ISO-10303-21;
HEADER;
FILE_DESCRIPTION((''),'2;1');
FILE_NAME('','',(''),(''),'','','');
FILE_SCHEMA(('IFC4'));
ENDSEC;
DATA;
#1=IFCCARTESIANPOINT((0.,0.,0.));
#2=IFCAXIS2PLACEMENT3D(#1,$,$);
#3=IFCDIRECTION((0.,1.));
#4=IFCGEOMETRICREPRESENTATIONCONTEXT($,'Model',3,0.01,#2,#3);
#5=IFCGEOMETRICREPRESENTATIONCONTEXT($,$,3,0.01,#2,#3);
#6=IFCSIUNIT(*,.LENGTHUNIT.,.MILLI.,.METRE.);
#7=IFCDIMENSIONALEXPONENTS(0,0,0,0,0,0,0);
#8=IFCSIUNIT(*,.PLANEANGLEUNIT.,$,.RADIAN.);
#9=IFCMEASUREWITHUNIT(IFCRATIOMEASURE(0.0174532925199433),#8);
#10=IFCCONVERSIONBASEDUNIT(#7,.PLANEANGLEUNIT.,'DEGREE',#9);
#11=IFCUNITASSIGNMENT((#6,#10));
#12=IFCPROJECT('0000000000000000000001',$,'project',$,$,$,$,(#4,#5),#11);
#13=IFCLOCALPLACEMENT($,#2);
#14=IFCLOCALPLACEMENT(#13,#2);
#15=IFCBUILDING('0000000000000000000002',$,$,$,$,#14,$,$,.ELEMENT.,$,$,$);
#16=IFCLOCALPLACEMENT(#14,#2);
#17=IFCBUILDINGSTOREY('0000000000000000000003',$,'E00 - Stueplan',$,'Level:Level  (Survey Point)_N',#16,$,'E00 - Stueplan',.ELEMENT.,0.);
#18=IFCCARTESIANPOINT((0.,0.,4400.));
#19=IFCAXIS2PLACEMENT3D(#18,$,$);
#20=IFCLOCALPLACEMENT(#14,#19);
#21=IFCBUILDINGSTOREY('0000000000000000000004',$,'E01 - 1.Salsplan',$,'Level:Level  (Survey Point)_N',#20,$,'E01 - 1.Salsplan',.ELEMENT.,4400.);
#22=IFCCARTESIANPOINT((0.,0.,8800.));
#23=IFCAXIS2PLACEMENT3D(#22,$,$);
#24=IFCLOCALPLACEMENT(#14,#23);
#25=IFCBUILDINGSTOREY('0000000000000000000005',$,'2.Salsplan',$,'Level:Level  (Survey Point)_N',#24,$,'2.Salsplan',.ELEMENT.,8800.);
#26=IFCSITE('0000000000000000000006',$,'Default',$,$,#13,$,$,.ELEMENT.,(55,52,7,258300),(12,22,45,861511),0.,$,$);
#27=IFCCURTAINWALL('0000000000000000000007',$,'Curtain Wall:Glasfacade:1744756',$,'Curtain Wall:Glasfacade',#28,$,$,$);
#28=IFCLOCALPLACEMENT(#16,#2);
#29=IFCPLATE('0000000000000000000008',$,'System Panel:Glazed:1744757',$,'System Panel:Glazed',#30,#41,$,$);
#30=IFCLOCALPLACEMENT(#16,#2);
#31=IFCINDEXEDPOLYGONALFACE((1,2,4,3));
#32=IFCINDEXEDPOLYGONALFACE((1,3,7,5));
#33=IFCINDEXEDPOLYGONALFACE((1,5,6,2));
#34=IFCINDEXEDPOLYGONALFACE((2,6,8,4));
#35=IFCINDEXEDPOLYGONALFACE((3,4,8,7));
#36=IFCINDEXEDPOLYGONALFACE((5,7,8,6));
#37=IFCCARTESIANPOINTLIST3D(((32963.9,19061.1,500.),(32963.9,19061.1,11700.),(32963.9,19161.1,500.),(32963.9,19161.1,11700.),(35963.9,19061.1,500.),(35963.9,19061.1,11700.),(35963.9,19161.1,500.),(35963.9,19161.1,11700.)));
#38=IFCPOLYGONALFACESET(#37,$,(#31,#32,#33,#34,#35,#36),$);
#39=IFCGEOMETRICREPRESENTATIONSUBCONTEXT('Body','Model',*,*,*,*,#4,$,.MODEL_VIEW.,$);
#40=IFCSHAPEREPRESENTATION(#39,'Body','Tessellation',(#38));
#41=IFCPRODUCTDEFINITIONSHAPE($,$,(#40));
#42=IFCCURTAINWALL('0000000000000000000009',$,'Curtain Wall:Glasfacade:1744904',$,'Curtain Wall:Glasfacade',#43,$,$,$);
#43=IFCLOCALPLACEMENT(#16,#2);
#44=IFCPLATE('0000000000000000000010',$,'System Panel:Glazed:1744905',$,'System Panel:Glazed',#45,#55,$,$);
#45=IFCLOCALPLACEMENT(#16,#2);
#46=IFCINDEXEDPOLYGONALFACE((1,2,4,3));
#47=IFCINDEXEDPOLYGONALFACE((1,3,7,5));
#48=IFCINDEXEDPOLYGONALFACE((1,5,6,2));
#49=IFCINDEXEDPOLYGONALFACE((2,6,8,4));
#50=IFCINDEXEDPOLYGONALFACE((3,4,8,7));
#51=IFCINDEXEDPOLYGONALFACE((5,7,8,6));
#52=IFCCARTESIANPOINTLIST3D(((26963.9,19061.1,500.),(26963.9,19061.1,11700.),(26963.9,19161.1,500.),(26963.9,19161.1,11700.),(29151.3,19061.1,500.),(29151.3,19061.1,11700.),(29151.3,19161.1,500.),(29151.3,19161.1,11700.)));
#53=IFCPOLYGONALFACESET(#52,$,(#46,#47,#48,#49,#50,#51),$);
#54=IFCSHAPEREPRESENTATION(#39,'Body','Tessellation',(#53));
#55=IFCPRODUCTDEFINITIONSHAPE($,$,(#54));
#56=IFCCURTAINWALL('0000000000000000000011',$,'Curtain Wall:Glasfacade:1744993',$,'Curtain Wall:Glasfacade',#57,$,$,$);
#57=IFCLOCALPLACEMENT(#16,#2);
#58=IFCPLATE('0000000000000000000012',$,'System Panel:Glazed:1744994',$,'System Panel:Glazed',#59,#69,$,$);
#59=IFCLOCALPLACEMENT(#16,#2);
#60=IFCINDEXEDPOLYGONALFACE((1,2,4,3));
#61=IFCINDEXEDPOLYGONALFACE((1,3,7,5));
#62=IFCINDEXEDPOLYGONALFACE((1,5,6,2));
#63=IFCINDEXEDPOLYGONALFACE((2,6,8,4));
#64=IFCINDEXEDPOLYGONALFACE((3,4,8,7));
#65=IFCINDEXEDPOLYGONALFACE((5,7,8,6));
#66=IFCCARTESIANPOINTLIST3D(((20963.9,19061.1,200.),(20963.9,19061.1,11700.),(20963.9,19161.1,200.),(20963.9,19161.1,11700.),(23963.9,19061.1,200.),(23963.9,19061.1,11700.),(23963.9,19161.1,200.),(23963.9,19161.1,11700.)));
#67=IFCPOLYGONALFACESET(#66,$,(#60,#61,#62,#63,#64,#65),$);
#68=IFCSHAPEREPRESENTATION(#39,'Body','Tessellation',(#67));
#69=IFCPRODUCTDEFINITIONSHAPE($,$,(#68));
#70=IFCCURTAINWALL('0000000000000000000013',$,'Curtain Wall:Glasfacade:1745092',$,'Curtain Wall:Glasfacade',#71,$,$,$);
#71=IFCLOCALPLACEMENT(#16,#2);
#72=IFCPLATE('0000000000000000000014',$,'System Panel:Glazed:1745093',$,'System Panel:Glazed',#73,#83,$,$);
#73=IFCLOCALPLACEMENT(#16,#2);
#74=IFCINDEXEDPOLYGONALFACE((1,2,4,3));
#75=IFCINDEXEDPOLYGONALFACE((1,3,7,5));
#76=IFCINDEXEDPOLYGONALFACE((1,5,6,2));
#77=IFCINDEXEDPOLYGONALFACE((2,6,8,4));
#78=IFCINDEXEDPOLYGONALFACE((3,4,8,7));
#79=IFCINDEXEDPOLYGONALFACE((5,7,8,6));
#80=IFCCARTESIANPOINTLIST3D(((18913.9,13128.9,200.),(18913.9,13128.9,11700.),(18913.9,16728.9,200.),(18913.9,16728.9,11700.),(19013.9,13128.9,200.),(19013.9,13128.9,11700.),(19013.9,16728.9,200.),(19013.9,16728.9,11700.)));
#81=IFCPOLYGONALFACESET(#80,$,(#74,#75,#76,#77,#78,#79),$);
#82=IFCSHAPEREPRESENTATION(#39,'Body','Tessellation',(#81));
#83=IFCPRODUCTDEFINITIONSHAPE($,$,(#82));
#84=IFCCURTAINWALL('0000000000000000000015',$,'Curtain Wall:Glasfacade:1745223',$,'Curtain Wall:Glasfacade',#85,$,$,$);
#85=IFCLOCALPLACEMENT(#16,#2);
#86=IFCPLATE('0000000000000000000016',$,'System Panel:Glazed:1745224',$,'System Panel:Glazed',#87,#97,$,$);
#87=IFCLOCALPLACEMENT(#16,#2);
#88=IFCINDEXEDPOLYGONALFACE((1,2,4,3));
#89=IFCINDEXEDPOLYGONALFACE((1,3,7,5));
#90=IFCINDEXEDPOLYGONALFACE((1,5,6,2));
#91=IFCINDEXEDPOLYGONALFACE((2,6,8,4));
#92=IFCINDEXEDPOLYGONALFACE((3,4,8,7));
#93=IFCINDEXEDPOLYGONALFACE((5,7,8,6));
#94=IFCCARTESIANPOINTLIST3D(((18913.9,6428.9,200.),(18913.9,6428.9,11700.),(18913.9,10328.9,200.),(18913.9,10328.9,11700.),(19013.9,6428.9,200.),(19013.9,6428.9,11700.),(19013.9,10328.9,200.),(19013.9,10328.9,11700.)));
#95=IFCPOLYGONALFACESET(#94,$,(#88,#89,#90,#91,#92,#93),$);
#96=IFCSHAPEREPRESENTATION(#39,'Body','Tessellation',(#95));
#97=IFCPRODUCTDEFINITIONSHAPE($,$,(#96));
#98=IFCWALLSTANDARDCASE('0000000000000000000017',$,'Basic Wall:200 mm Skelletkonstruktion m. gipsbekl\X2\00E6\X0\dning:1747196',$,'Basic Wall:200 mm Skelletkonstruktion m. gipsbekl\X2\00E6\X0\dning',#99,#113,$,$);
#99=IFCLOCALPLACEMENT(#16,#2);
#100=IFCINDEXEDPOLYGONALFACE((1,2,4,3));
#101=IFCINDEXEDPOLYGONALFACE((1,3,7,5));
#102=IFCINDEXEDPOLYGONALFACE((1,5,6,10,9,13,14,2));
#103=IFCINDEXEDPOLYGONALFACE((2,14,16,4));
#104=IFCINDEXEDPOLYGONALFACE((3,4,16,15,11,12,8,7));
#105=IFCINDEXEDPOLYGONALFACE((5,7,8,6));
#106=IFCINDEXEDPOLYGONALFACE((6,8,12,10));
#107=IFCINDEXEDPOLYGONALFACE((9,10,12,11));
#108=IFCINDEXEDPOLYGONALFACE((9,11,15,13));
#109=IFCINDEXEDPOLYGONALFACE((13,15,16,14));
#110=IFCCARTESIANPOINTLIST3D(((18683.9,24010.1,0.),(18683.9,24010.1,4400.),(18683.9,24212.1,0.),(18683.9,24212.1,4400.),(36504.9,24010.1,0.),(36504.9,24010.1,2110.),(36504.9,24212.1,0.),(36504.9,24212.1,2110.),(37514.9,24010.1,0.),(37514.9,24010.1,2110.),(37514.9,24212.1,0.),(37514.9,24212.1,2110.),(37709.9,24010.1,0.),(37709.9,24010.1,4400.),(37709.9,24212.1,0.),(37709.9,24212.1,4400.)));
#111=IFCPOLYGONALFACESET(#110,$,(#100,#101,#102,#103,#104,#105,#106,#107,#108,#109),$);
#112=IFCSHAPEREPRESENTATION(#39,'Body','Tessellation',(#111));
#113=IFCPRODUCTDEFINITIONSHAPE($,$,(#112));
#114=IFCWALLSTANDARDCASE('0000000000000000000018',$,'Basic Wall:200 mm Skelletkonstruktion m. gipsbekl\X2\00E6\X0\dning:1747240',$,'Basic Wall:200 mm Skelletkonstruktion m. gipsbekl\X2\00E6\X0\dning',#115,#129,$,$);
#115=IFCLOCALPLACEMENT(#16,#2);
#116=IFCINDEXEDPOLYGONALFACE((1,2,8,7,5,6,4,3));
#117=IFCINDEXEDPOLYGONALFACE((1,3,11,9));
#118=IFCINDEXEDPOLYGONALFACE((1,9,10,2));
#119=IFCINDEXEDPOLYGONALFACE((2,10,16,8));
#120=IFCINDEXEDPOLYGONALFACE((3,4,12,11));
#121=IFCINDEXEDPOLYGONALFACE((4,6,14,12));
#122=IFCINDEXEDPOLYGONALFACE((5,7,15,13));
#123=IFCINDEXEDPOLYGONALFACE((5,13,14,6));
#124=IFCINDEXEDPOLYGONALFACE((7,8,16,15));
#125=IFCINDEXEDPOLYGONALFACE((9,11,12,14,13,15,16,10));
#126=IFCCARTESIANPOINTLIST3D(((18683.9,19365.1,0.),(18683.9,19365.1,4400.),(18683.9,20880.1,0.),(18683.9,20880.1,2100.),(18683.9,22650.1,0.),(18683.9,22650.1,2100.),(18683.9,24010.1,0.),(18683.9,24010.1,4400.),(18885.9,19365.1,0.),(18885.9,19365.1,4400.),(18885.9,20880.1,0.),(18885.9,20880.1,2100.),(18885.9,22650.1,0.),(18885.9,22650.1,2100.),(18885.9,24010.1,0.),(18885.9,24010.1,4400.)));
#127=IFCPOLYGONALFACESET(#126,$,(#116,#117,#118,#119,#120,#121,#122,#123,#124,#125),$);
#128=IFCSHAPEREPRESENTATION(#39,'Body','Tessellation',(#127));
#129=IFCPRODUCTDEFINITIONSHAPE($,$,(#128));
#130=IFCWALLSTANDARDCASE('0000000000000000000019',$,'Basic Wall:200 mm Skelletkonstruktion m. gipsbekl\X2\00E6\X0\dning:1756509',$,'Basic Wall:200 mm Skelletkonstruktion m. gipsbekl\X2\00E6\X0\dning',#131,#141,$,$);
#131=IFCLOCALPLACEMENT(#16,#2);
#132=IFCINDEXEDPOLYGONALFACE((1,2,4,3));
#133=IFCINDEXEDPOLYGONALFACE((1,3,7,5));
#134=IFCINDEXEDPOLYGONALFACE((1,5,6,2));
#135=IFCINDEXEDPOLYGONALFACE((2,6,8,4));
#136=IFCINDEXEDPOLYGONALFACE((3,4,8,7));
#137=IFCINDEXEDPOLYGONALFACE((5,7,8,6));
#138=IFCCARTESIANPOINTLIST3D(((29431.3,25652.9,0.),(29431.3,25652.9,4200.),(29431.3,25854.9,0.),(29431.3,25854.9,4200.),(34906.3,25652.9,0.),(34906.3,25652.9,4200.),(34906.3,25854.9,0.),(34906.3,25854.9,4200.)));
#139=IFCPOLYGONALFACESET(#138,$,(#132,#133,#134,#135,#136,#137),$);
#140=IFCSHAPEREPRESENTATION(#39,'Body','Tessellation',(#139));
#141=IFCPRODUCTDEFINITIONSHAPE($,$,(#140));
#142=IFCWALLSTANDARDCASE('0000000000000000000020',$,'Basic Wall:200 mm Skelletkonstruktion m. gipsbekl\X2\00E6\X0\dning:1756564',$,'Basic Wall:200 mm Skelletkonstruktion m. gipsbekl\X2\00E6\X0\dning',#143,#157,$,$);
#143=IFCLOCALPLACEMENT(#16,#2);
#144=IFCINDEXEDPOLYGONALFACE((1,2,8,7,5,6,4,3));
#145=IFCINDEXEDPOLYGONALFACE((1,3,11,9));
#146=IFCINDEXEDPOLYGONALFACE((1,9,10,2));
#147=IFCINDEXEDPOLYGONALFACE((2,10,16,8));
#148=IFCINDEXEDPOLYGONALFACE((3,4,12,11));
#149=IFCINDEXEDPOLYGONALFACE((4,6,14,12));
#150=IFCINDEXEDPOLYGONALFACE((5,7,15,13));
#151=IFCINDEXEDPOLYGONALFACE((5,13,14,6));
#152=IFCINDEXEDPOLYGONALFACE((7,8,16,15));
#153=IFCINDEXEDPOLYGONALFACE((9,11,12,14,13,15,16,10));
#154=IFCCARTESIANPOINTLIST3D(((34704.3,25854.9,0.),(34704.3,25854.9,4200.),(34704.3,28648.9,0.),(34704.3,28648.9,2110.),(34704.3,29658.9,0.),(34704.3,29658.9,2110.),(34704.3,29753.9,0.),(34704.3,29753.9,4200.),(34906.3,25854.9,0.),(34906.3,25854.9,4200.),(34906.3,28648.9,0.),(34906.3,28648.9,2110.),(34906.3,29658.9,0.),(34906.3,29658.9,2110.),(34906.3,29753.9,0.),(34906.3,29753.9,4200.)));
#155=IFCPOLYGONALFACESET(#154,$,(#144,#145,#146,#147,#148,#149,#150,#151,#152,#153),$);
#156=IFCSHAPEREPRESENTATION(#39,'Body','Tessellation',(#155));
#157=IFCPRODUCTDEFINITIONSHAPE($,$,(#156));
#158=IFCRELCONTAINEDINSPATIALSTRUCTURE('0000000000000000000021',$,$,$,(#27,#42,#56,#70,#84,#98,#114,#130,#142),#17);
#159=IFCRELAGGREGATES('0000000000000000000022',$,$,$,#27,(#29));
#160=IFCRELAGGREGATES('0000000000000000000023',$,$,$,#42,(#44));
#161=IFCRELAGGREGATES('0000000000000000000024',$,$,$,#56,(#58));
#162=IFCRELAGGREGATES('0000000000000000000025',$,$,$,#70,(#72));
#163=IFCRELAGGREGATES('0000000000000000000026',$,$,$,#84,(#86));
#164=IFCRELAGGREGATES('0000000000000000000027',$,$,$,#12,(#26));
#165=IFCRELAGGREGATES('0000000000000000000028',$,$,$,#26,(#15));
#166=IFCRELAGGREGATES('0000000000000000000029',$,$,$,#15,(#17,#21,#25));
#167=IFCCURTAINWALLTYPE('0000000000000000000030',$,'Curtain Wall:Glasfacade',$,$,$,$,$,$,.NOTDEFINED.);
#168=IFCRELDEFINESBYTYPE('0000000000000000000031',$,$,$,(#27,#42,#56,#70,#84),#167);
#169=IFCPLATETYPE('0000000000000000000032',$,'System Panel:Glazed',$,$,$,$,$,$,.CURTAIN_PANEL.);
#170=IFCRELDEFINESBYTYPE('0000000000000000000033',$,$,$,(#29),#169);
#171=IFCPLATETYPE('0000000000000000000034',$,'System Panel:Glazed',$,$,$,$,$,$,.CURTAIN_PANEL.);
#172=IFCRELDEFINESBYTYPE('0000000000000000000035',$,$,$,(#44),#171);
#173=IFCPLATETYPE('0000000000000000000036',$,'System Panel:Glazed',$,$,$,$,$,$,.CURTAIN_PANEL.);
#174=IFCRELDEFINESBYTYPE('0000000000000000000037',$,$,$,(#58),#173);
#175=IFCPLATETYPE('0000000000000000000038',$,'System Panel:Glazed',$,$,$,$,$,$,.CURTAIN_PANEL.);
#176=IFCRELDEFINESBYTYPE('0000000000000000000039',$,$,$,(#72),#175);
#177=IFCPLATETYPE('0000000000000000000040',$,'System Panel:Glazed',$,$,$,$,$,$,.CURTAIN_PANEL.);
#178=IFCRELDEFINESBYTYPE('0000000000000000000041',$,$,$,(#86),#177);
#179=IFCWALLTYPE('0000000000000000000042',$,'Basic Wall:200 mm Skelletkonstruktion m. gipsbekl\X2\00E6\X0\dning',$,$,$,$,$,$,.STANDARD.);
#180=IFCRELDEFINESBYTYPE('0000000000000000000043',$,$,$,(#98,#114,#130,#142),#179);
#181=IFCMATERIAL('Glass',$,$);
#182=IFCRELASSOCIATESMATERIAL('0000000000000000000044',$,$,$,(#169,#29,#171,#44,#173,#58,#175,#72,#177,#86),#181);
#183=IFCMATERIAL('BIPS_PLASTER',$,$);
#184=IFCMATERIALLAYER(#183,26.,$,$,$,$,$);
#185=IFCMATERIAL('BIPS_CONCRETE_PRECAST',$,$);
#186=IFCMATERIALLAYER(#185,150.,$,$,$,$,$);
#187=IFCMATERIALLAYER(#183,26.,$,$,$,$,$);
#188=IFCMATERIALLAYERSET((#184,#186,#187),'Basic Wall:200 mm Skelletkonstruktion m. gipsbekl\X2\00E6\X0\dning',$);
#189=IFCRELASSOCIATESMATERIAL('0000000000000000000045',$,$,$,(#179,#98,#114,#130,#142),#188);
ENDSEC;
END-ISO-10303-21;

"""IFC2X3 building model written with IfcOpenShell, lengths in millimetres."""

from ifc_helpers import new_model, entity, si_unit, converted_unit, direction, frame, frame_2d, origin, origin_2d_with_axis, place, context, subcontext, project, spatial, rectangle, extrude, source, transform, mapped, material, layer, layer_set, layer_usage, type_object, type_shapes, element, aggregate, save


model = new_model("IFC2X3")

# Units and contexts
model_context = context("Model", 3, precision=0.01, world=origin(), true_north=direction((0.0, 1.0)))
context_of_model = context(None, 3, precision=0.01, world=origin(), true_north=direction((0.0, 1.0)))
body_context = subcontext(model_context, "Body", "Model", "MODEL_VIEW")
ifc_project = project(units=[si_unit("LENGTHUNIT", "METRE", prefix="MILLI"), converted_unit("PLANEANGLEUNIT", "DEGREE", entity("IfcRatioMeasure", 0.0174532925199433), si_unit("PLANEANGLEUNIT", "RADIAN"), dimensions=[0, 0, 0, 0, 0, 0, 0])], contexts=[model_context, context_of_model])

# Site, building, storey
site_placement = place(None, origin())
site = spatial("IfcSite", under=ifc_project, at=site_placement, Name="Default", CompositionType="ELEMENT", RefLatitude=(55, 52, 7, 258300), RefLongitude=(12, 22, 45, 861511), RefElevation=0.0)
building_placement = place(site_placement, origin())
building = spatial("IfcBuilding", under=site, at=building_placement, CompositionType="ELEMENT")
storey_1_placement = place(building_placement, origin())
storey_1 = spatial("IfcBuildingStorey", under=building, at=storey_1_placement, Name="E00 - Stueplan", ObjectType="Level:Level  (Survey Point)_N", LongName="E00 - Stueplan", CompositionType="ELEMENT", Elevation=0.0)

# Curtain walls, plates
curtain_wall_type = type_object("IfcCurtainWallType", Name="Curtain Wall:Glasfacade", PredefinedType="NOTDEFINED")
curtain_wall_1_placement = place(storey_1_placement, origin())
curtain_wall_1 = element("IfcCurtainWall", 1, at=curtain_wall_1_placement, inside=storey_1, type_object=curtain_wall_type, Name="Curtain Wall:Glasfacade:1744756", ObjectType="Curtain Wall:Glasfacade")
ifc_material_1 = material(Name="Glass")
plate_type_1 = type_object("IfcPlateType", Name="System Panel:Glazed", PredefinedType="CURTAIN_PANEL", material=ifc_material_1)
shared_shape_1 = source(origin(), body_context, "Body", "SweptSolid", [
    extrude(rectangle(XDim=100.0, YDim=3000.0, at=origin_2d_with_axis()), frame((0.0, 0.0, 0.0), z_axis=(0.0, 0.0, 1.0), x_axis=(0.0, 1.0, 0.0)), (0.0, 0.0, 1.0), 11200.0),
])
type_shapes(plate_type_1, [shared_shape_1])
plate_1_placement = place(curtain_wall_1_placement, frame((34463.9, 19111.1, 500.0), z_axis=(0.0, 0.0, 1.0), x_axis=(-1.0, 0.0, 0.0)))
plate_1 = element("IfcPlate", 2, at=plate_1_placement, type_object=plate_type_1, material=ifc_material_1, Name="System Panel:Glazed:1744757", ObjectType="System Panel:Glazed", context=body_context, shape_type="MappedRepresentation", body=[
    mapped(shared_shape_1, transform((0.0, 0.0, 0.0), scale=1.0)),
])
aggregate(curtain_wall_1, [plate_1])
curtain_wall_2_placement = place(storey_1_placement, origin())
curtain_wall_2 = element("IfcCurtainWall", 3, at=curtain_wall_2_placement, inside=storey_1, type_object=curtain_wall_type, Name="Curtain Wall:Glasfacade:1744904", ObjectType="Curtain Wall:Glasfacade")
plate_type_2 = type_object("IfcPlateType", Name="System Panel:Glazed", PredefinedType="CURTAIN_PANEL", material=ifc_material_1)
shared_shape_2 = source(origin(), body_context, "Body", "SweptSolid", [
    extrude(rectangle(XDim=100.0, YDim=2187.4, at=origin_2d_with_axis()), frame((0.0, 0.0, 0.0), z_axis=(0.0, 0.0, 1.0), x_axis=(0.0, 1.0, 0.0)), (0.0, 0.0, 1.0), 11200.0),
])
type_shapes(plate_type_2, [shared_shape_2])
plate_2_placement = place(curtain_wall_2_placement, frame((28057.6, 19111.1, 500.0), z_axis=(0.0, 0.0, 1.0), x_axis=(-1.0, 0.0, 0.0)))
plate_2 = element("IfcPlate", 4, at=plate_2_placement, type_object=plate_type_2, material=ifc_material_1, Name="System Panel:Glazed:1744905", ObjectType="System Panel:Glazed", context=body_context, shape_type="MappedRepresentation", body=[
    mapped(shared_shape_2, transform((0.0, 0.0, 0.0), scale=1.0)),
])
aggregate(curtain_wall_2, [plate_2])
curtain_wall_3_placement = place(storey_1_placement, origin())
curtain_wall_3 = element("IfcCurtainWall", 5, at=curtain_wall_3_placement, inside=storey_1, type_object=curtain_wall_type, Name="Curtain Wall:Glasfacade:1744993", ObjectType="Curtain Wall:Glasfacade")
plate_type_3 = type_object("IfcPlateType", Name="System Panel:Glazed", PredefinedType="CURTAIN_PANEL", material=ifc_material_1)
shared_shape_3 = source(origin(), body_context, "Body", "SweptSolid", [
    extrude(rectangle(XDim=100.0, YDim=3000.0, at=origin_2d_with_axis()), frame((0.0, 0.0, 0.0), z_axis=(0.0, 0.0, 1.0), x_axis=(0.0, 1.0, 0.0)), (0.0, 0.0, 1.0), 11500.0),
])
type_shapes(plate_type_3, [shared_shape_3])
plate_3_placement = place(curtain_wall_3_placement, frame((22463.9, 19111.1, 200.0), z_axis=(0.0, 0.0, 1.0), x_axis=(-1.0, 0.0, 0.0)))
plate_3 = element("IfcPlate", 6, at=plate_3_placement, type_object=plate_type_3, material=ifc_material_1, Name="System Panel:Glazed:1744994", ObjectType="System Panel:Glazed", context=body_context, shape_type="MappedRepresentation", body=[
    mapped(shared_shape_3, transform((0.0, 0.0, 0.0), scale=1.0)),
])
aggregate(curtain_wall_3, [plate_3])
curtain_wall_4_placement = place(storey_1_placement, origin())
curtain_wall_4 = element("IfcCurtainWall", 7, at=curtain_wall_4_placement, inside=storey_1, type_object=curtain_wall_type, Name="Curtain Wall:Glasfacade:1745092", ObjectType="Curtain Wall:Glasfacade")
plate_type_4 = type_object("IfcPlateType", Name="System Panel:Glazed", PredefinedType="CURTAIN_PANEL", material=ifc_material_1)
shared_shape_4 = source(origin(), body_context, "Body", "SweptSolid", [
    extrude(rectangle(XDim=100.0, YDim=3600.0, at=origin_2d_with_axis()), frame((0.0, 0.0, 0.0), z_axis=(0.0, 0.0, 1.0), x_axis=(0.0, 1.0, 0.0)), (0.0, 0.0, 1.0), 11500.0),
])
type_shapes(plate_type_4, [shared_shape_4])
plate_4_placement = place(curtain_wall_4_placement, frame((18963.9, 14928.9, 200.0), z_axis=(0.0, 0.0, 1.0), x_axis=(0.0, -1.0, 0.0)))
plate_4 = element("IfcPlate", 8, at=plate_4_placement, type_object=plate_type_4, material=ifc_material_1, Name="System Panel:Glazed:1745093", ObjectType="System Panel:Glazed", context=body_context, shape_type="MappedRepresentation", body=[
    mapped(shared_shape_4, transform((0.0, 0.0, 0.0), scale=1.0)),
])
aggregate(curtain_wall_4, [plate_4])
curtain_wall_5_placement = place(storey_1_placement, origin())
curtain_wall_5 = element("IfcCurtainWall", 9, at=curtain_wall_5_placement, inside=storey_1, type_object=curtain_wall_type, Name="Curtain Wall:Glasfacade:1745223", ObjectType="Curtain Wall:Glasfacade")
plate_type_5 = type_object("IfcPlateType", Name="System Panel:Glazed", PredefinedType="CURTAIN_PANEL", material=ifc_material_1)
shared_shape_5 = source(origin(), body_context, "Body", "SweptSolid", [
    extrude(rectangle(XDim=100.0, YDim=3900.0, at=origin_2d_with_axis()), frame((0.0, 0.0, 0.0), z_axis=(0.0, 0.0, 1.0), x_axis=(0.0, 1.0, 0.0)), (0.0, 0.0, 1.0), 11500.0),
])
type_shapes(plate_type_5, [shared_shape_5])
plate_5_placement = place(curtain_wall_5_placement, frame((18963.9, 8378.9, 200.0), z_axis=(0.0, 0.0, 1.0), x_axis=(0.0, -1.0, 0.0)))
plate_5 = element("IfcPlate", 10, at=plate_5_placement, type_object=plate_type_5, material=ifc_material_1, Name="System Panel:Glazed:1745224", ObjectType="System Panel:Glazed", context=body_context, shape_type="MappedRepresentation", body=[
    mapped(shared_shape_5, transform((0.0, 0.0, 0.0), scale=1.0)),
])
aggregate(curtain_wall_5, [plate_5])

# Shared definitions
ifc_material_2 = material(Name="BIPS_CONCRETE_PRECAST")

# Shared definitions
storey_2_placement = place(building_placement, frame((0.0, 0.0, 4400.0)))
storey_2 = spatial("IfcBuildingStorey", under=building, at=storey_2_placement, Name="E01 - 1.Salsplan", ObjectType="Level:Level  (Survey Point)_N", LongName="E01 - 1.Salsplan", CompositionType="ELEMENT", Elevation=4400.0)

# Shared definitions
storey_3_placement = place(building_placement, frame((0.0, 0.0, 8800.0)))
storey_3 = spatial("IfcBuildingStorey", under=building, at=storey_3_placement, Name="2.Salsplan", ObjectType="Level:Level  (Survey Point)_N", LongName="2.Salsplan", CompositionType="ELEMENT", Elevation=8800.0)

# Walls, openings
ifc_material_3 = material(Name="BIPS_PLASTER")
ifc_layer_1 = layer(ifc_material_3, 26.0)
ifc_layer_2 = layer(ifc_material_2, 150.0)
ifc_layer_3 = layer(ifc_material_3, 26.0)
ifc_layer_set_1 = layer_set([ifc_layer_1, ifc_layer_2, ifc_layer_3], Name="Basic Wall:200 mm Skelletkonstruktion m. gipsbeklædning")
ifc_layer_usage_1 = layer_usage(ifc_layer_set_1, "AXIS2", "NEGATIVE", 101.0)
wall_type_1 = type_object("IfcWallType", Name="Basic Wall:200 mm Skelletkonstruktion m. gipsbeklædning", PredefinedType="STANDARD", material=ifc_layer_set_1)
wall_1_placement = place(storey_1_placement, frame((37709.9, 24111.1, 0.0), z_axis=(0.0, 0.0, 1.0), x_axis=(-1.0, 0.0, 0.0)))
wall_1 = element("IfcWallStandardCase", 11, at=wall_1_placement, inside=storey_1, type_object=wall_type_1, material=ifc_layer_usage_1, Name="Basic Wall:200 mm Skelletkonstruktion m. gipsbeklædning:1747196", ObjectType="Basic Wall:200 mm Skelletkonstruktion m. gipsbeklædning", context=body_context, shape_type="SweptSolid", body=[
    extrude(rectangle(XDim=19026.0, YDim=202.0, at=frame_2d((9513.0, 0.0), x_axis=(-1.0, 0.0))), origin(), (0.0, 0.0, 1.0), 4400.0),
])
opening_1_placement = place(wall_1_placement, frame((1205.0, 101.0, 0.0)))
element("IfcOpeningElement", 12, at=opening_1_placement, cuts=wall_1, ObjectType="Opening", context=body_context, shape_type="SweptSolid", body=[
    extrude(rectangle(XDim=2110.0, YDim=1010.0, at=frame_2d((1055.0, 505.0), x_axis=(1.0, 0.0))), frame((0.0, 0.0, 0.0), z_axis=(0.0, -1.0, 0.0), x_axis=(0.0, 0.0, 1.0)), (0.0, 0.0, 1.0), 202.0),
])
ifc_layer_usage_2 = layer_usage(ifc_layer_set_1, "AXIS2", "NEGATIVE", 101.0)
wall_2_placement = place(storey_1_placement, frame((18784.9, 24010.1, 0.0), z_axis=(0.0, 0.0, 1.0), x_axis=(0.0, -1.0, 0.0)))
wall_2 = element("IfcWallStandardCase", 13, at=wall_2_placement, inside=storey_1, type_object=wall_type_1, material=ifc_layer_usage_2, Name="Basic Wall:200 mm Skelletkonstruktion m. gipsbeklædning:1747240", ObjectType="Basic Wall:200 mm Skelletkonstruktion m. gipsbeklædning", context=body_context, shape_type="SweptSolid", body=[
    extrude(rectangle(XDim=4645.0, YDim=202.0, at=frame_2d((2322.5, 0.0), x_axis=(-1.0, 0.0))), origin(), (0.0, 0.0, 1.0), 4400.0),
])
opening_2_placement = place(wall_2_placement, frame((1360.0, -101.0, 0.0)))
element("IfcOpeningElement", 14, at=opening_2_placement, cuts=wall_2, ObjectType="Opening", context=body_context, shape_type="SweptSolid", body=[
    extrude(rectangle(XDim=2100.0, YDim=1770.0, at=frame_2d((1050.0, 885.0), x_axis=(1.0, 0.0))), frame((0.0, 0.0, 0.0), z_axis=(0.0, 1.0, 0.0), x_axis=(0.0, 0.0, 1.0)), (0.0, 0.0, 1.0), 202.0),
])

# Wall
ifc_layer_usage_3 = layer_usage(ifc_layer_set_1, "AXIS2", "NEGATIVE", 101.0)
wall_3_placement = place(storey_1_placement, frame((29431.3, 25753.9, 0.0)))
element("IfcWallStandardCase", 15, at=wall_3_placement, inside=storey_1, type_object=wall_type_1, material=ifc_layer_usage_3, Name="Basic Wall:200 mm Skelletkonstruktion m. gipsbeklædning:1756509", ObjectType="Basic Wall:200 mm Skelletkonstruktion m. gipsbeklædning", context=body_context, shape_type="SweptSolid", body=[
    extrude(rectangle(XDim=5475.0, YDim=202.0, at=frame_2d((2737.5, 0.0), x_axis=(-1.0, 0.0))), origin(), (0.0, 0.0, 1.0), 4200.0),
])

# Wall, opening
ifc_layer_usage_4 = layer_usage(ifc_layer_set_1, "AXIS2", "NEGATIVE", 101.0)
wall_4_placement = place(storey_1_placement, frame((34805.3, 25854.9, 0.0), z_axis=(0.0, 0.0, 1.0), x_axis=(0.0, 1.0, 0.0)))
wall_4 = element("IfcWallStandardCase", 16, at=wall_4_placement, inside=storey_1, type_object=wall_type_1, material=ifc_layer_usage_4, Name="Basic Wall:200 mm Skelletkonstruktion m. gipsbeklædning:1756564", ObjectType="Basic Wall:200 mm Skelletkonstruktion m. gipsbeklædning", context=body_context, shape_type="SweptSolid", body=[
    extrude(rectangle(XDim=3899.0, YDim=202.0, at=frame_2d((1949.5, 0.0), x_axis=(-1.0, 0.0))), origin(), (0.0, 0.0, 1.0), 4200.0),
])
opening_3_placement = place(wall_4_placement, frame((2794.0, -101.0, 0.0)))
element("IfcOpeningElement", 17, at=opening_3_placement, cuts=wall_4, ObjectType="Opening", context=body_context, shape_type="SweptSolid", body=[
    extrude(rectangle(XDim=2110.0, YDim=1010.0, at=frame_2d((1055.0, 505.0), x_axis=(1.0, 0.0))), frame((0.0, 0.0, 0.0), z_axis=(0.0, 1.0, 0.0), x_axis=(0.0, 0.0, 1.0)), (0.0, 0.0, 1.0), 202.0),
])

save(model, "model.ifc")
